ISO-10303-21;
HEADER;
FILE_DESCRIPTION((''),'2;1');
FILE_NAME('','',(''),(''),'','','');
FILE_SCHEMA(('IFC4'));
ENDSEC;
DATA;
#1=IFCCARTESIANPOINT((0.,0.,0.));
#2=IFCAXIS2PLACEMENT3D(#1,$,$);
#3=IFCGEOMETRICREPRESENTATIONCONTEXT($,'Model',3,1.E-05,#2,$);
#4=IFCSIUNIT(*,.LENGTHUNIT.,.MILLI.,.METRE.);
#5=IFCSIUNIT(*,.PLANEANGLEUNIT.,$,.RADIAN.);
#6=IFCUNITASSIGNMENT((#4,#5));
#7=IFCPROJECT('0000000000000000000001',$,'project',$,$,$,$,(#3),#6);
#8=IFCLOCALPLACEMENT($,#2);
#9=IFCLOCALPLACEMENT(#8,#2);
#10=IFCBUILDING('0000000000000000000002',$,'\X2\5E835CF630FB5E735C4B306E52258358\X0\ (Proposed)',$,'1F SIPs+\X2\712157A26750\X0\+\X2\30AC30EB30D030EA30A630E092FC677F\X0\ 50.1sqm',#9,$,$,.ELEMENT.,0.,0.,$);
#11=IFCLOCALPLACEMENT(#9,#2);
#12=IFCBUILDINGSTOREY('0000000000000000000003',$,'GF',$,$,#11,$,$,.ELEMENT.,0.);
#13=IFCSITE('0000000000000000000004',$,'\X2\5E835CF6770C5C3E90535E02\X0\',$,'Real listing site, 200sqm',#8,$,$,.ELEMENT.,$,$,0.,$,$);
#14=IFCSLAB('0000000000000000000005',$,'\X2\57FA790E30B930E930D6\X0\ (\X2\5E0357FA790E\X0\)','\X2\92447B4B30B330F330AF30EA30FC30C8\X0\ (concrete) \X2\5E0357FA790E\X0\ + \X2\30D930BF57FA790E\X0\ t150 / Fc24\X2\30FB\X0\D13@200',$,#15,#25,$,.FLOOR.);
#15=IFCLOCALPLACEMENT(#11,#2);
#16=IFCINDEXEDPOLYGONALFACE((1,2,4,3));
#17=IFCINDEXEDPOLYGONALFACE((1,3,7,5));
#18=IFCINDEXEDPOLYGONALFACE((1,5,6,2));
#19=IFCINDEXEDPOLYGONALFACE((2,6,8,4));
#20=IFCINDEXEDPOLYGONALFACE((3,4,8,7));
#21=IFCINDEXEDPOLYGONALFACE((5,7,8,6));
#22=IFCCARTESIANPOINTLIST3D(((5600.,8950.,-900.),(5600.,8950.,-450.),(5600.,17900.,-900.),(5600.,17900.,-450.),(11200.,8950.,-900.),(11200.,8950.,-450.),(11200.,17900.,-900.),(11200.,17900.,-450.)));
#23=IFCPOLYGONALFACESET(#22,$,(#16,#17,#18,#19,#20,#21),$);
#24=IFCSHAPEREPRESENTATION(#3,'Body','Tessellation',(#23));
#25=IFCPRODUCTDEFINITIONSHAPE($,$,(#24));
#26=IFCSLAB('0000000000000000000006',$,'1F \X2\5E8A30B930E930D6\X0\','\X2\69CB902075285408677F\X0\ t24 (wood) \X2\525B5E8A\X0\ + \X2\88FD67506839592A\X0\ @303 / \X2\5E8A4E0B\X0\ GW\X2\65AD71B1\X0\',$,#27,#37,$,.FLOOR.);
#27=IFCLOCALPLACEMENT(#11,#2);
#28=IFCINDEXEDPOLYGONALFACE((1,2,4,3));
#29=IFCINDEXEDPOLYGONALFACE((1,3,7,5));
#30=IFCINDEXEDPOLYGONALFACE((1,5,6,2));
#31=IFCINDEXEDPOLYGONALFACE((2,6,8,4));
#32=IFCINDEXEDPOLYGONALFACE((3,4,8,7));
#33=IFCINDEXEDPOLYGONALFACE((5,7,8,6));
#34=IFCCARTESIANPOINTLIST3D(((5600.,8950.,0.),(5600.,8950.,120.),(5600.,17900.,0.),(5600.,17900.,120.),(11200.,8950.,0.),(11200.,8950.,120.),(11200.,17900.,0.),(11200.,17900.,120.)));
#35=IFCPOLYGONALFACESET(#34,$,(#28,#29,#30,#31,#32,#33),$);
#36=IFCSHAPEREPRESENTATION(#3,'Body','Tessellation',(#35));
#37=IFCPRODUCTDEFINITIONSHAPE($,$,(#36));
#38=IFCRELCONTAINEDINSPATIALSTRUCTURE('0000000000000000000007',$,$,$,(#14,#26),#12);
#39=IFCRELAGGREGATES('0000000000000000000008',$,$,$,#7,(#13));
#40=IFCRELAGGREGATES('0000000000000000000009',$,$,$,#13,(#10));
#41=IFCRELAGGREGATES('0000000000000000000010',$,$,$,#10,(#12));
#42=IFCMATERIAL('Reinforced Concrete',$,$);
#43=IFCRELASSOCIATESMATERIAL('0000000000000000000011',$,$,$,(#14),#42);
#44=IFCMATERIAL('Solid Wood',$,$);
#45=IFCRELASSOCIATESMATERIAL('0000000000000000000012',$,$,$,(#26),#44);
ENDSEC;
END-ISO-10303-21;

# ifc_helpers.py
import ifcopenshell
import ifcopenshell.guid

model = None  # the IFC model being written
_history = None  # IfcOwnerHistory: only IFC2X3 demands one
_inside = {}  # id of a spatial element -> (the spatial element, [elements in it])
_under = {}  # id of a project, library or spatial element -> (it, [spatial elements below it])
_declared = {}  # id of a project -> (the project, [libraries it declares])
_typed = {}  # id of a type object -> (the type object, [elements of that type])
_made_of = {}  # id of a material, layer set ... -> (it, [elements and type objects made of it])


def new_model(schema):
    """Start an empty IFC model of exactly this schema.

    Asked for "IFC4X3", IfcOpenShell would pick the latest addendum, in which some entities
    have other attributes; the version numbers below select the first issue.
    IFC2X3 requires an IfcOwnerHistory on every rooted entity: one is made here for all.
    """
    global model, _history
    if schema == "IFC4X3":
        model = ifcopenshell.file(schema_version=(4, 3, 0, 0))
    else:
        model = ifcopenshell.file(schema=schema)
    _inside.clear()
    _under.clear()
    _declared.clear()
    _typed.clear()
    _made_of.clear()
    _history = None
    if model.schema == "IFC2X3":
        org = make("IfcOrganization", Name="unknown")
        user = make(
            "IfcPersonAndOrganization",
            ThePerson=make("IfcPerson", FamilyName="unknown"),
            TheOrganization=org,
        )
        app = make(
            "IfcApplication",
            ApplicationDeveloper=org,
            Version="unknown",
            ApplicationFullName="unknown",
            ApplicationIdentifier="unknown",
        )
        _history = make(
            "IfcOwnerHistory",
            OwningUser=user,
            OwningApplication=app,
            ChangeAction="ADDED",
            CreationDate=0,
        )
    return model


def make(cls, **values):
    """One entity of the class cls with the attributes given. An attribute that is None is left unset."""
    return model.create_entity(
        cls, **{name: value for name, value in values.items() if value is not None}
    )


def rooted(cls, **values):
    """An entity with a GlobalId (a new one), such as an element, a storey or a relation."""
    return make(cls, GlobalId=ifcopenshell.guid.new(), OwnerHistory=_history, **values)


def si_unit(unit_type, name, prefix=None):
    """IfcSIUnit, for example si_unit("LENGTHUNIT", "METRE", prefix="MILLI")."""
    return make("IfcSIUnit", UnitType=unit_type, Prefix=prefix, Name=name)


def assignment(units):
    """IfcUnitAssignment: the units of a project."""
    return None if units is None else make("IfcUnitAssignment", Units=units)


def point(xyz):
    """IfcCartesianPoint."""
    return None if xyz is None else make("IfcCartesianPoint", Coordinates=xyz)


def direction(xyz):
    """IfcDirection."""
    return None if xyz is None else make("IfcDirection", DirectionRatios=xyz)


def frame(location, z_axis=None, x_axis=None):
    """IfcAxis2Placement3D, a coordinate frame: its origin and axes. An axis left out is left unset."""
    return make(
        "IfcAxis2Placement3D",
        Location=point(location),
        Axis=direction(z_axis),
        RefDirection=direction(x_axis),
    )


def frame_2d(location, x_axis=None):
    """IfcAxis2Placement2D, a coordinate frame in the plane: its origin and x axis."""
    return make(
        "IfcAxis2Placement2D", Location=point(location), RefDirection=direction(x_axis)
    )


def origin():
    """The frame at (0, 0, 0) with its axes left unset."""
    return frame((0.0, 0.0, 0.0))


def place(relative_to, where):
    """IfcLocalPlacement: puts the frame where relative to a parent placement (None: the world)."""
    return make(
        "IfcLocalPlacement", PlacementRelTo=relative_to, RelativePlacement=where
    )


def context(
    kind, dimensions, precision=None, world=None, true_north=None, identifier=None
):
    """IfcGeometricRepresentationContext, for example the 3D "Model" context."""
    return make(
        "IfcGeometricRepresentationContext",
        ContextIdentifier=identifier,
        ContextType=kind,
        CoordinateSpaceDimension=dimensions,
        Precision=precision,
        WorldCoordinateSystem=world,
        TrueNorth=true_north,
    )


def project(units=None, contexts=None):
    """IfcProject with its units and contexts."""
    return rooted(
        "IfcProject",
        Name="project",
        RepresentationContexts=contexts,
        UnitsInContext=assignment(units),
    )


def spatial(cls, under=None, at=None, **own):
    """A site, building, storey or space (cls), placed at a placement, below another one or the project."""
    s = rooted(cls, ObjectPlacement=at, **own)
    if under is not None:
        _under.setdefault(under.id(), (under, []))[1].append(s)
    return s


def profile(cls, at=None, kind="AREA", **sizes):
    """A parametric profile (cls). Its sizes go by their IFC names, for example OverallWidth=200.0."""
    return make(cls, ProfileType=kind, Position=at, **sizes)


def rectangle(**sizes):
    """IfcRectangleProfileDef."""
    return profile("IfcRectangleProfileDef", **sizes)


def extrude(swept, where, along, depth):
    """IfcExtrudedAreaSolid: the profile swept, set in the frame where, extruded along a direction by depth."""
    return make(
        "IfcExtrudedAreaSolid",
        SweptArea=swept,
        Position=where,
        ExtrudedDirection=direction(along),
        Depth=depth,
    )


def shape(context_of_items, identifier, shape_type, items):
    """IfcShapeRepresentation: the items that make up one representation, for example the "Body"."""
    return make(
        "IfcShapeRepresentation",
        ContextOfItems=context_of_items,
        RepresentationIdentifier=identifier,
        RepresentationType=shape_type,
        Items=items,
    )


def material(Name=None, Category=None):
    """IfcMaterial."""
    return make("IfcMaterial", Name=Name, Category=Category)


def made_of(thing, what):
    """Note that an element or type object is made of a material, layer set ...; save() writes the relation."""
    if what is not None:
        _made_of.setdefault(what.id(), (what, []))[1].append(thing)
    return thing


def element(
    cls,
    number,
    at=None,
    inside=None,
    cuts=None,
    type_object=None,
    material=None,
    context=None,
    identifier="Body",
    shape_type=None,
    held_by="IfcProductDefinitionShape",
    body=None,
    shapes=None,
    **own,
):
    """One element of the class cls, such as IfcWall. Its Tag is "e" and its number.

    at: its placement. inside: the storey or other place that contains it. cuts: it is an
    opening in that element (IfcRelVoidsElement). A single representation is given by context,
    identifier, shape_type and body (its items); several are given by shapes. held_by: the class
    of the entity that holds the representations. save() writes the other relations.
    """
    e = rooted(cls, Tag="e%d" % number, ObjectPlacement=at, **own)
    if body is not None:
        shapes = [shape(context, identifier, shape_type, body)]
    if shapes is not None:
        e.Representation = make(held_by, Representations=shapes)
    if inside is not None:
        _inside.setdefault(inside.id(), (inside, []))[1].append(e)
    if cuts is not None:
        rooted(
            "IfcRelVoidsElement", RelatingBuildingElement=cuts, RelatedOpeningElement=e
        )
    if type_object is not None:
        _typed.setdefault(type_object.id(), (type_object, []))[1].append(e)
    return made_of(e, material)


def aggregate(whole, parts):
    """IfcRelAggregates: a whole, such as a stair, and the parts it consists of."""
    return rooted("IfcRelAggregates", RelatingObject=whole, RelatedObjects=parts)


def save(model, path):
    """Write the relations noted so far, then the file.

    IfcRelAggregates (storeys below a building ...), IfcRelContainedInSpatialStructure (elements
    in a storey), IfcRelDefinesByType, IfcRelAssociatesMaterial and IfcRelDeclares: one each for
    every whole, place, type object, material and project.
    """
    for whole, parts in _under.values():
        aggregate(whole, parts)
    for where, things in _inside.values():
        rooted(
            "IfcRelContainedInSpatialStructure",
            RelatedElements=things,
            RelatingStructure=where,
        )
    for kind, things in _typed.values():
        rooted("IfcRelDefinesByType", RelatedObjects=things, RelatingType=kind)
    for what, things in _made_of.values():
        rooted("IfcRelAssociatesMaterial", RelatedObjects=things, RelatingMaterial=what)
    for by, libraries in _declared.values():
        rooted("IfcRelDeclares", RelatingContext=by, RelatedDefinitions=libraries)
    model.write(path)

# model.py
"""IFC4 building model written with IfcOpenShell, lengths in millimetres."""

from ifc_helpers import new_model, si_unit, frame, frame_2d, origin, place, context, project, spatial, rectangle, extrude, material, element, save


model = new_model("IFC4")

# Units and contexts
model_context = context("Model", 3, precision=1e-05, world=origin())
ifc_project = project(units=[si_unit("LENGTHUNIT", "METRE", prefix="MILLI"), si_unit("PLANEANGLEUNIT", "RADIAN")], contexts=[model_context])

# Site, building, storey
site_placement = place(None, origin())
site = spatial("IfcSite", under=ifc_project, at=site_placement, Name="広島県尾道市", ObjectType="Real listing site, 200sqm", CompositionType="ELEMENT", RefElevation=0.0)
building_placement = place(site_placement, origin())
building = spatial("IfcBuilding", under=site, at=building_placement, Name="広島・平屋の別荘 (Proposed)", ObjectType="1F SIPs+無垢材+ガルバリウム鋼板 50.1sqm", CompositionType="ELEMENT", ElevationOfRefHeight=0.0, ElevationOfTerrain=0.0)
storey_placement = place(building_placement, origin())
storey = spatial("IfcBuildingStorey", under=building, at=storey_placement, Name="GF", CompositionType="ELEMENT", Elevation=0.0)

# Shared definitions
ifc_material_1 = material(Name="Solid Wood")

# Slabs
ifc_material_2 = material(Name="Reinforced Concrete")
slab_1_placement = place(storey_placement, frame((2800.0, 4475.0, -450.0)))
element("IfcSlab", 1, at=slab_1_placement, inside=storey, material=ifc_material_2, Name="基礎スラブ (布基礎)", Description="鉄筋コンクリート (concrete) 布基礎 + ベタ基礎 t150 / Fc24・D13@200", PredefinedType="FLOOR", context=model_context, shape_type="SweptSolid", body=[
    extrude(rectangle(XDim=5600.0, YDim=8950.0, at=frame_2d((2800.0, 4475.0))), frame((2800.0, 4475.0, -450.0)), (0.0, 0.0, 1.0), 450.0),
])
slab_2_placement = place(storey_placement, frame((2800.0, 4475.0, 0.0)))
element("IfcSlab", 2, at=slab_2_placement, inside=storey, material=ifc_material_1, Name="1F 床スラブ", Description="構造用合板 t24 (wood) 剛床 + 製材根太 @303 / 床下 GW断熱", PredefinedType="FLOOR", context=model_context, shape_type="SweptSolid", body=[
    extrude(rectangle(XDim=5600.0, YDim=8950.0, at=frame_2d((2800.0, 4475.0))), frame((2800.0, 4475.0, 0.0)), (0.0, 0.0, 1.0), 120.0),
])

save(model, "model.ifc")
